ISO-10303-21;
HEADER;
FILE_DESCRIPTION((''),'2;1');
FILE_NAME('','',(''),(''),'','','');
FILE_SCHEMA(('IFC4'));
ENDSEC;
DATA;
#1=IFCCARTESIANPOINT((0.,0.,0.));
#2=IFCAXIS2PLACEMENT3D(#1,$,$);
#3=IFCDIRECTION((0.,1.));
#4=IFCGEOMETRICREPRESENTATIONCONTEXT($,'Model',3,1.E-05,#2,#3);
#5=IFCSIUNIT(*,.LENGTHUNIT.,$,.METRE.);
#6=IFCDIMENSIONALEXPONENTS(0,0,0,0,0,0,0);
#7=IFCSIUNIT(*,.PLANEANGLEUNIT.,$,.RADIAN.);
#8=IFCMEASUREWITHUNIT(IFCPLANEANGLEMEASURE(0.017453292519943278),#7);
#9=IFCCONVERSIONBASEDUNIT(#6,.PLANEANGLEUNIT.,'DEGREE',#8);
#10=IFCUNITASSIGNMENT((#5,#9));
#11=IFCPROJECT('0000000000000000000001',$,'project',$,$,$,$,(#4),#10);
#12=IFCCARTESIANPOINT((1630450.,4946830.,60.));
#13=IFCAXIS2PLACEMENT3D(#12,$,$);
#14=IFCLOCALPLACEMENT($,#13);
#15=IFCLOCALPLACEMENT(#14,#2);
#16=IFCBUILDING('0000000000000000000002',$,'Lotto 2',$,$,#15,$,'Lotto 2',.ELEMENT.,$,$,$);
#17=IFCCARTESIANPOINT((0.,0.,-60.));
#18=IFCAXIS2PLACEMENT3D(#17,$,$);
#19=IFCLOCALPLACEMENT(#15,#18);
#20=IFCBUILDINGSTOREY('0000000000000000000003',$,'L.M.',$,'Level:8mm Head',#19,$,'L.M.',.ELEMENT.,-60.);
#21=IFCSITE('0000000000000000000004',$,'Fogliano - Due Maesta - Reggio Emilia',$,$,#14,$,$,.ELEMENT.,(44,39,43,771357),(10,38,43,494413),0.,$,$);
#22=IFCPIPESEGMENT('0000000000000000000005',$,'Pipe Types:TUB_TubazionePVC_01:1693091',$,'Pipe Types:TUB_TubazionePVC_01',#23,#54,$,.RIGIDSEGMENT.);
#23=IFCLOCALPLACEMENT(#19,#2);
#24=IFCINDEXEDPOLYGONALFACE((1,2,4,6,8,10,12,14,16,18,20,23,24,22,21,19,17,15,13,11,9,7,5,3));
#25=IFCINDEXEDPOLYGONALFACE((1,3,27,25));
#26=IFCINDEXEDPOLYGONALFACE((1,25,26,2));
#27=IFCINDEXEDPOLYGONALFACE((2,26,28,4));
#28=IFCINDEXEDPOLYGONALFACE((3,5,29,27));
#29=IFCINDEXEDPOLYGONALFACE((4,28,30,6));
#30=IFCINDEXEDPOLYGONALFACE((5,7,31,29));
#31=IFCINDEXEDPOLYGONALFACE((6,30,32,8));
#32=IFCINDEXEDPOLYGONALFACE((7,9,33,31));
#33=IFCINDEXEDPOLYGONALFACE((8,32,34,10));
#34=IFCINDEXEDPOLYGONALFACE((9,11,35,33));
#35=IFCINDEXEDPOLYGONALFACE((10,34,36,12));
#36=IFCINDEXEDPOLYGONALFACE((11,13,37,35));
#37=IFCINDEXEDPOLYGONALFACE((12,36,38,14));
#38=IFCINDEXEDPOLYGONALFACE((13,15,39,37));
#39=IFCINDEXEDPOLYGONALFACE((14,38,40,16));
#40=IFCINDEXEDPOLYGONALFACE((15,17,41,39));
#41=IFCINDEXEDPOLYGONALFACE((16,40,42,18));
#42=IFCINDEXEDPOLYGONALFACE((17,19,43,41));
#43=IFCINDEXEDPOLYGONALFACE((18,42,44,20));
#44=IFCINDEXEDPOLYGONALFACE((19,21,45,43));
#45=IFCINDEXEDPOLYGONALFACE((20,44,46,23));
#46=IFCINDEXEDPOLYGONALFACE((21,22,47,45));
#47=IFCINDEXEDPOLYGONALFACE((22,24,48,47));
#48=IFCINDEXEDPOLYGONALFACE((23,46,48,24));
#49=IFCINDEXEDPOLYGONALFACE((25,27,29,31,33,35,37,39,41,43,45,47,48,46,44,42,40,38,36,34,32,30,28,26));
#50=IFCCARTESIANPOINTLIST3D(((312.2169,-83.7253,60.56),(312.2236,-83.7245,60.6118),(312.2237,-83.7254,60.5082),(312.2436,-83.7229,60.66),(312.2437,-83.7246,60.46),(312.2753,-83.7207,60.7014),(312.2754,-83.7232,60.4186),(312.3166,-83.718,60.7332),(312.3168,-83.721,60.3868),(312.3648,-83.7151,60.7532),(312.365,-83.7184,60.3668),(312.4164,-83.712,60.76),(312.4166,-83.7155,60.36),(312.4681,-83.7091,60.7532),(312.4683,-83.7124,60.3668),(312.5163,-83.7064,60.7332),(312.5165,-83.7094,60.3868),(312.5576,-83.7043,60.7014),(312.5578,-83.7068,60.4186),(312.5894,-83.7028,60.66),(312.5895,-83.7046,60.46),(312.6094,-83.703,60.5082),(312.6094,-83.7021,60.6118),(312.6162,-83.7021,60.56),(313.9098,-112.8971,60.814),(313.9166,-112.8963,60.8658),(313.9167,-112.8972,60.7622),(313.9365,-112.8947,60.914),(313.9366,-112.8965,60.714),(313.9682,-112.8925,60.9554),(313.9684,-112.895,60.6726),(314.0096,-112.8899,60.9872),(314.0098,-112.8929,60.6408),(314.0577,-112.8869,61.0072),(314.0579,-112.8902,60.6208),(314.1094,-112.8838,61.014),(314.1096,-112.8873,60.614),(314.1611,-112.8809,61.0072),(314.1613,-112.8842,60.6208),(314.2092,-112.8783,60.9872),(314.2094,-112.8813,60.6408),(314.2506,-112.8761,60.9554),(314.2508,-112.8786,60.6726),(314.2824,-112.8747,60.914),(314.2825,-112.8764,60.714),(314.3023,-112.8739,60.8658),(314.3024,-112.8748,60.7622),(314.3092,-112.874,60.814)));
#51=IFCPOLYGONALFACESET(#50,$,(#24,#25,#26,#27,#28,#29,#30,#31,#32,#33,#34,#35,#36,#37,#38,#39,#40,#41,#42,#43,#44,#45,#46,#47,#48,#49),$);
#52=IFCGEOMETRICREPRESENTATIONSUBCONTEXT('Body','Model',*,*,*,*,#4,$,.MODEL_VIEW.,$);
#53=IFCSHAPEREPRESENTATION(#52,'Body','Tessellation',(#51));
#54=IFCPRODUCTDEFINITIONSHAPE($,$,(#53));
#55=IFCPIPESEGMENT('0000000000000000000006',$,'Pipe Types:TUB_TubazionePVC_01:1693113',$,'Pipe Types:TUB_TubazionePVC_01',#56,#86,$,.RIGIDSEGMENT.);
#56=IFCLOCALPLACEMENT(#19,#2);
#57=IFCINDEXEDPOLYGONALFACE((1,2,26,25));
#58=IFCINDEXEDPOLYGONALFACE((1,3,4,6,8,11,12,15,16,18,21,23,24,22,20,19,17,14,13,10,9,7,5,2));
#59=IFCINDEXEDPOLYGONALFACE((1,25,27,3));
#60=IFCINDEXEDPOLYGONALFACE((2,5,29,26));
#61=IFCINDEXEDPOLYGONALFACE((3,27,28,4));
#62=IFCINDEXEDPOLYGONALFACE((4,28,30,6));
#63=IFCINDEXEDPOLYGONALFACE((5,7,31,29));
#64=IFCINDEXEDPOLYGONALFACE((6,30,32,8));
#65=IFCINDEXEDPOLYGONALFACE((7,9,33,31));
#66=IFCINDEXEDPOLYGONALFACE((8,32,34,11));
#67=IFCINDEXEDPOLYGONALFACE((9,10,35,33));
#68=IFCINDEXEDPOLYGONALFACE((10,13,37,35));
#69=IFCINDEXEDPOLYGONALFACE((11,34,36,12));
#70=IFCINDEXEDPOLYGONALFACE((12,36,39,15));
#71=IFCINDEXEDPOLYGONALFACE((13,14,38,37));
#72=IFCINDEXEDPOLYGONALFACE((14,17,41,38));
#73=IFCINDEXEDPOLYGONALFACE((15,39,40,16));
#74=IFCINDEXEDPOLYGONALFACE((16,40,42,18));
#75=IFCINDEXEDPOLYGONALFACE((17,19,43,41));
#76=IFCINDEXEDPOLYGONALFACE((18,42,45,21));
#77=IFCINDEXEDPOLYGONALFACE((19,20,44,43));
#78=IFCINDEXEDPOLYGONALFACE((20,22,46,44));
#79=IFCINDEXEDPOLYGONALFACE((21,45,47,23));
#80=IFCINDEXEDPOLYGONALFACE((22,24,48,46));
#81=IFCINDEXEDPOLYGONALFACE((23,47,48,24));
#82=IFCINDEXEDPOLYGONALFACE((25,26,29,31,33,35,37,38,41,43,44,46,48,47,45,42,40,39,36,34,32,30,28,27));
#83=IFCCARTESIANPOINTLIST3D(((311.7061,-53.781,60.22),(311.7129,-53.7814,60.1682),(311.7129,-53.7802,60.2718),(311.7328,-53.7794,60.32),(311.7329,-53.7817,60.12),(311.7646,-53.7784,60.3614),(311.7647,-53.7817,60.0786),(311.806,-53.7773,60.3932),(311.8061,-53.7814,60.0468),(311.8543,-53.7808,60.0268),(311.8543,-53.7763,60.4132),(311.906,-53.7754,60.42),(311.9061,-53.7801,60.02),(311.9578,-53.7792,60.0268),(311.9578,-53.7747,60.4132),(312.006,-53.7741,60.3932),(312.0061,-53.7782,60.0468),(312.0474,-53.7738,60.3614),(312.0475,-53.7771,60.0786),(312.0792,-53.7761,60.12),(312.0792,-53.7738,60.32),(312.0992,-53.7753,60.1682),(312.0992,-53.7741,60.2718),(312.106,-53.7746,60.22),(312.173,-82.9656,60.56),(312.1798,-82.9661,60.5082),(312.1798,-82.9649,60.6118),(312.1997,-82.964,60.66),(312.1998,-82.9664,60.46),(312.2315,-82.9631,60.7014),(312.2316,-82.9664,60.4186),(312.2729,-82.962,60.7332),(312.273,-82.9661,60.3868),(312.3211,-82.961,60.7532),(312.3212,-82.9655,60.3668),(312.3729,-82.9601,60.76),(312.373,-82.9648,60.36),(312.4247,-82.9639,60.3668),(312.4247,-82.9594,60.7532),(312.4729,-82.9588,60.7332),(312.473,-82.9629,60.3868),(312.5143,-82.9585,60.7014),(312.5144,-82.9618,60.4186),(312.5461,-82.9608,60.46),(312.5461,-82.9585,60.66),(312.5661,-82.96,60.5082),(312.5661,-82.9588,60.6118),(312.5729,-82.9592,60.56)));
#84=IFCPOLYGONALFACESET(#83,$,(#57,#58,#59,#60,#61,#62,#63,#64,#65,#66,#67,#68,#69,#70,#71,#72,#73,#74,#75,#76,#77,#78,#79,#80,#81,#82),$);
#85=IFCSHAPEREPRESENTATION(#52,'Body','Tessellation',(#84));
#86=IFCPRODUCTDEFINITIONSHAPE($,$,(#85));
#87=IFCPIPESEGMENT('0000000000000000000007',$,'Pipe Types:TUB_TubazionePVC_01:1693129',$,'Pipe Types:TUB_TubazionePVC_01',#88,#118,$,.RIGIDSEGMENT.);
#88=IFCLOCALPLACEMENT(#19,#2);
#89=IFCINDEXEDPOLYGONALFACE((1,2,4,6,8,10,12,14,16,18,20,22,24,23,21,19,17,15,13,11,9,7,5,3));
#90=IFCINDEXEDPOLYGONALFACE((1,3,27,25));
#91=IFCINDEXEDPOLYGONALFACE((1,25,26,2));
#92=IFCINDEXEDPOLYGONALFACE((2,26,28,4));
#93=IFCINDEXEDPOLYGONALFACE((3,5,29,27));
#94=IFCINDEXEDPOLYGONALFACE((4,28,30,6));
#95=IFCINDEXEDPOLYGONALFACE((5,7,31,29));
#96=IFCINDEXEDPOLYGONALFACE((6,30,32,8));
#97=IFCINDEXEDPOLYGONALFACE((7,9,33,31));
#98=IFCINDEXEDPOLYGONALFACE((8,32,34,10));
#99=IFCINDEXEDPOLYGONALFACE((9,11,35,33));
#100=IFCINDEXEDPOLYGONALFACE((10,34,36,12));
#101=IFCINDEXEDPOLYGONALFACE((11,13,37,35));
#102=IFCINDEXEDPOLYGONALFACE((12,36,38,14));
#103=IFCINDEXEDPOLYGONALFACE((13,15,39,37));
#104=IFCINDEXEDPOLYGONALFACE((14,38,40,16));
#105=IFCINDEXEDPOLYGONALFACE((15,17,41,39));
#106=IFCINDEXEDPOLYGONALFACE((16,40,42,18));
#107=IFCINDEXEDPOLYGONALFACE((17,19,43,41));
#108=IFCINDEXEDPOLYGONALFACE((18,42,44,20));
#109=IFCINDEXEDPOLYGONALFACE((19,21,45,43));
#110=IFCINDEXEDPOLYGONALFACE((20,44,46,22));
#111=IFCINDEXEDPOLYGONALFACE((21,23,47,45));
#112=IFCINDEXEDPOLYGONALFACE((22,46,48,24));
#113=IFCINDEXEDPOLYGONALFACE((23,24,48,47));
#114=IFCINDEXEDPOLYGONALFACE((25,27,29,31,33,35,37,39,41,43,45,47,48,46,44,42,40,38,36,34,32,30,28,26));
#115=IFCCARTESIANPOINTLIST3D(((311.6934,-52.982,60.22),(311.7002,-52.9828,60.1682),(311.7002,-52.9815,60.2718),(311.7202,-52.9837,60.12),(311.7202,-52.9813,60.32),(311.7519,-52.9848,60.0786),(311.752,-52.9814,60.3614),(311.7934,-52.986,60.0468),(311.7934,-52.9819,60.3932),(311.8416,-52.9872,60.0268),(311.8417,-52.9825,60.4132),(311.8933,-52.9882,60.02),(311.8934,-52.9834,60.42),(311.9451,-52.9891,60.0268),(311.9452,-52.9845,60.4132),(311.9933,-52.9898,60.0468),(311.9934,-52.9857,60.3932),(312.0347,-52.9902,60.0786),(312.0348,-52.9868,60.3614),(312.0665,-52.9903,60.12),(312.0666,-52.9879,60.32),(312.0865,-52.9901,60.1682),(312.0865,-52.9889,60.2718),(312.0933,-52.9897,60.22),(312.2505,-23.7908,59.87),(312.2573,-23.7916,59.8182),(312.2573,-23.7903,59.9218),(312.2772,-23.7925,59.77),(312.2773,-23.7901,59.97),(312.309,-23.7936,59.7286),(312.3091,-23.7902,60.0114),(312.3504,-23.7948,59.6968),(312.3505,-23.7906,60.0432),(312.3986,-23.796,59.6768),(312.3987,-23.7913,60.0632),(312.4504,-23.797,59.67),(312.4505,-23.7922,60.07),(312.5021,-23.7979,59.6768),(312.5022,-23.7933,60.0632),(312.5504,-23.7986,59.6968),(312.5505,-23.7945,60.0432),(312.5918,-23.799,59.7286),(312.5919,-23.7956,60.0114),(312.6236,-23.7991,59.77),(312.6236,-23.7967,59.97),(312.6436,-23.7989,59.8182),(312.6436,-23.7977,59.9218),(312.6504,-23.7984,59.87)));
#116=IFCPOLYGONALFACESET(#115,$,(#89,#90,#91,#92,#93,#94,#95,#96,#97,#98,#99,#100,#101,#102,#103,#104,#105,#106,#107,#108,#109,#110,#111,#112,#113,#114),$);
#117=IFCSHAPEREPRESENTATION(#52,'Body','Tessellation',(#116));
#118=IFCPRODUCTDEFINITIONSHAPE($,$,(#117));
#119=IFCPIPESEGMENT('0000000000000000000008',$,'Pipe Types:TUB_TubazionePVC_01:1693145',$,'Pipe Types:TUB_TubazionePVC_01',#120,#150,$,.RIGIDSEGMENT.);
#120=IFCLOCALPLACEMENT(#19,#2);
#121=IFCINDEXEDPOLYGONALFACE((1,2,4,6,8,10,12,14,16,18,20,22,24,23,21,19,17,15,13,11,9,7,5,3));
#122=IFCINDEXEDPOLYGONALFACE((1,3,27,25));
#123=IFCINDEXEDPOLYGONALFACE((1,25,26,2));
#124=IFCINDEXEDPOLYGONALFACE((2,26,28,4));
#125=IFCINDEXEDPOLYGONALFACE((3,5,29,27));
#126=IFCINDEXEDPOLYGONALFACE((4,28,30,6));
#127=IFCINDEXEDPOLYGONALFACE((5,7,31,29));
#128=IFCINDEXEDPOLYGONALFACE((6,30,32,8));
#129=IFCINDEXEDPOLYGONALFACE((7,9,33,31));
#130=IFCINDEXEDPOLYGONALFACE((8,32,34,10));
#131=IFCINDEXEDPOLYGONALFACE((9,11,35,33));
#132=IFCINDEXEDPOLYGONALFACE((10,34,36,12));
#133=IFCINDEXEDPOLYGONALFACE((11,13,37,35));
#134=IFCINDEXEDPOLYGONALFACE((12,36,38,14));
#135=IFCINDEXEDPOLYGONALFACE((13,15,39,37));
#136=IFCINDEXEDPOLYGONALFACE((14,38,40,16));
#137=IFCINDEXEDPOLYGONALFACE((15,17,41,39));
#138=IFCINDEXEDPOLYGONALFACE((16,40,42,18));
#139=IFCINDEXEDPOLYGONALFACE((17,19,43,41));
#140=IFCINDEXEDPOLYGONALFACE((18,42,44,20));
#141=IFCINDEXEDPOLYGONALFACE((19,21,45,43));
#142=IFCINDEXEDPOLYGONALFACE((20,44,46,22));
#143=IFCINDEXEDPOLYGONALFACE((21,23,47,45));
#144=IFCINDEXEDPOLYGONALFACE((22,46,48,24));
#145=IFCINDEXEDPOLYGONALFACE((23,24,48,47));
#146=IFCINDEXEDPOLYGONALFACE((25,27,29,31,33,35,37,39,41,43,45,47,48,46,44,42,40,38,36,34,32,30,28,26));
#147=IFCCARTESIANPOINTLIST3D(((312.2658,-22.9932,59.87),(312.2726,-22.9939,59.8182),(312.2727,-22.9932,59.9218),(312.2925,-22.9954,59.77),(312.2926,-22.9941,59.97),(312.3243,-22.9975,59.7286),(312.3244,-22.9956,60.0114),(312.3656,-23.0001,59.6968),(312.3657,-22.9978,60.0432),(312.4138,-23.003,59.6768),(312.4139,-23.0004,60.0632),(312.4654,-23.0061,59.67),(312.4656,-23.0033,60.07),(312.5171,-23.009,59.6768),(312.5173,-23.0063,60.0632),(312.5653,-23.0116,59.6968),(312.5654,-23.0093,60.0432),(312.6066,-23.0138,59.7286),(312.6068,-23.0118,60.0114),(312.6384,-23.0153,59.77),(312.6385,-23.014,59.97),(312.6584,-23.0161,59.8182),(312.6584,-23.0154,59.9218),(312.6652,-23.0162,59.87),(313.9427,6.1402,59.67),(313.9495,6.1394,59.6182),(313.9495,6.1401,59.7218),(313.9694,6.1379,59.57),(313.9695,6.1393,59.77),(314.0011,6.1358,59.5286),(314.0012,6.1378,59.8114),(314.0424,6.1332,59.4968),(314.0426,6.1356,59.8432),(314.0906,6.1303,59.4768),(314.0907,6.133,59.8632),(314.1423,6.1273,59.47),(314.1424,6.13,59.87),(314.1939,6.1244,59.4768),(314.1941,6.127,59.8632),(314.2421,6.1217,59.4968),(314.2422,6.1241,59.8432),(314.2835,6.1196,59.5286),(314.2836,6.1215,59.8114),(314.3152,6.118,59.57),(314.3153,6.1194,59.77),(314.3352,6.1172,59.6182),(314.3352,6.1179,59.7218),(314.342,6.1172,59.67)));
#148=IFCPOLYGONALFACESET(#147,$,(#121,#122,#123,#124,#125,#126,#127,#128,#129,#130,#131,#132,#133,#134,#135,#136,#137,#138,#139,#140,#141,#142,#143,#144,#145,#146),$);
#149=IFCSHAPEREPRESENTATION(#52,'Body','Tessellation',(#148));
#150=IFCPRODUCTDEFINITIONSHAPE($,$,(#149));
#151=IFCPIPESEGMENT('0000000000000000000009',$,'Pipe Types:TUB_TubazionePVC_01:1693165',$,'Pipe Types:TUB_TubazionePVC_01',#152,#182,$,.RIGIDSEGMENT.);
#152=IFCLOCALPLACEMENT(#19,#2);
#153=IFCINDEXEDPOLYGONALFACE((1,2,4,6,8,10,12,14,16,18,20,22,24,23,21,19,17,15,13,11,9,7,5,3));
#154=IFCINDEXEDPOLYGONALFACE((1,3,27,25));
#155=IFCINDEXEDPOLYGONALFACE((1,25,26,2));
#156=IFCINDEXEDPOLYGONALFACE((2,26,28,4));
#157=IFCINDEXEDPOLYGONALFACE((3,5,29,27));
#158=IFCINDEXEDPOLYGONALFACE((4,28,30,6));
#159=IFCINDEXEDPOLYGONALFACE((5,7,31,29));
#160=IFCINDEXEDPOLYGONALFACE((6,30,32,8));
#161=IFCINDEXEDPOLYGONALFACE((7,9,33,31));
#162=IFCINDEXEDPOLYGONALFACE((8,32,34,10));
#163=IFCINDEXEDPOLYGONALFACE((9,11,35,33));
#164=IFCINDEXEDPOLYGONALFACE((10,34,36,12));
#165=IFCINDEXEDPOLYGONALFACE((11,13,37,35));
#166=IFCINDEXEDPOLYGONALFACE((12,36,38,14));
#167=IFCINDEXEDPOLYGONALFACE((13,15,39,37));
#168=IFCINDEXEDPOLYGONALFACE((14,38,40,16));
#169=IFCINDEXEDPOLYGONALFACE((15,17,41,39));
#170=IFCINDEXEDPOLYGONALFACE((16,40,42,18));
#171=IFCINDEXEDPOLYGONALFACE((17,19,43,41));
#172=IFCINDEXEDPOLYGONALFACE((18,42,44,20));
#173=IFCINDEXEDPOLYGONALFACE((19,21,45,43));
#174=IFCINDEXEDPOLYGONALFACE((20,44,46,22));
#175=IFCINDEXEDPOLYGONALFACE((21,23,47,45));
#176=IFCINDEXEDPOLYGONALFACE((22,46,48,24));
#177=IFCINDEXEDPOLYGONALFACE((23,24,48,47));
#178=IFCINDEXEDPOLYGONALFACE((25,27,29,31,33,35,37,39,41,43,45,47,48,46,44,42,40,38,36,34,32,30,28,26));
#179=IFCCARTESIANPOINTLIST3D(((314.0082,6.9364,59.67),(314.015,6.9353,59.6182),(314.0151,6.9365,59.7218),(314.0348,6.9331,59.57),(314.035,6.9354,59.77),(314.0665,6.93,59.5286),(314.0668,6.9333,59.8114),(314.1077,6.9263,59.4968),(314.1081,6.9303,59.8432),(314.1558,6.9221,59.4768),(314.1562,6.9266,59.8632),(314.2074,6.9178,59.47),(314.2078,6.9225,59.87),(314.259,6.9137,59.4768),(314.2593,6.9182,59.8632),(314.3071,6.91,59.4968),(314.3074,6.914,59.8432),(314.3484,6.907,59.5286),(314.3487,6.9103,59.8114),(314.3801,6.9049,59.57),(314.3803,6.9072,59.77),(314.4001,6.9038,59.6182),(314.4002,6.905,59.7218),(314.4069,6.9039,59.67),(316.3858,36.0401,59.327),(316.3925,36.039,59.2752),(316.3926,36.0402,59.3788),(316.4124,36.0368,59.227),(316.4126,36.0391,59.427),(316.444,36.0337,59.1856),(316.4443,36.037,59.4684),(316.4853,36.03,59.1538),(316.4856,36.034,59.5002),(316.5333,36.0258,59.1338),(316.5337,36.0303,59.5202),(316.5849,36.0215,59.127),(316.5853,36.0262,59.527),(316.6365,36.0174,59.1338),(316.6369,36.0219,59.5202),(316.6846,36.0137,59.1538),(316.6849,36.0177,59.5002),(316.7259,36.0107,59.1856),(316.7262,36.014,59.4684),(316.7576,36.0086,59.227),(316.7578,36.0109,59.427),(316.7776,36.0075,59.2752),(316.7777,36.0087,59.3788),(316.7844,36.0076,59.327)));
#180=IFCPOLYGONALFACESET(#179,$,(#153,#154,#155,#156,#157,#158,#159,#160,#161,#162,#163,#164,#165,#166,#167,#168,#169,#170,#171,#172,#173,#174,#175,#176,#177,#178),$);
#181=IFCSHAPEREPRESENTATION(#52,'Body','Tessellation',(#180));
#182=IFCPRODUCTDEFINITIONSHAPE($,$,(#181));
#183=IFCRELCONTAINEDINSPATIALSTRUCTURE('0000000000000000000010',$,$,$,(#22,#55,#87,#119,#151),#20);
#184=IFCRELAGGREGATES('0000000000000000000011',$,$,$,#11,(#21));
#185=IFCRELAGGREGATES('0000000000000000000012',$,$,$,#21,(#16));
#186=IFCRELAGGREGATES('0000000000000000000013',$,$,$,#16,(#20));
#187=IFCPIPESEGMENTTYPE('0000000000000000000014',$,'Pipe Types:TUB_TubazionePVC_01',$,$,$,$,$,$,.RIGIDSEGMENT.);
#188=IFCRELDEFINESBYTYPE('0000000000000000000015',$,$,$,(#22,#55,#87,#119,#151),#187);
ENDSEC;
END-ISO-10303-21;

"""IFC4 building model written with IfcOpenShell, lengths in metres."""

from ifc_helpers import new_model, entity, si_unit, converted_unit, direction, frame, origin, place, context, subcontext, project, spatial, arc, indexed_curve, outline, extrude, type_object, element, save


model = new_model("IFC4")

# Units and contexts
model_context = context("Model", 3, precision=1e-05, world=origin(), true_north=direction((0.0, 1.0)))
body_context = subcontext(model_context, "Body", "Model", "MODEL_VIEW")
ifc_project = project(units=[si_unit("LENGTHUNIT", "METRE"), converted_unit("PLANEANGLEUNIT", "DEGREE", entity("IfcPlaneAngleMeasure", 0.017453292519943278), si_unit("PLANEANGLEUNIT", "RADIAN"), dimensions=[0, 0, 0, 0, 0, 0, 0])], contexts=[model_context])

# Site, building, storey
site_placement = place(None, frame((1630450.0, 4946830.0, 60.0)))
site = spatial("IfcSite", under=ifc_project, at=site_placement, Name="Fogliano - Due Maesta - Reggio Emilia", CompositionType="ELEMENT", RefLatitude=(44, 39, 43, 771357), RefLongitude=(10, 38, 43, 494413), RefElevation=0.0)
building_placement = place(site_placement, origin())
building = spatial("IfcBuilding", under=site, at=building_placement, Name="Lotto 2", LongName="Lotto 2", CompositionType="ELEMENT")
storey_placement = place(building_placement, frame((0.0, 0.0, -60.0)))
storey = spatial("IfcBuildingStorey", under=building, at=storey_placement, Name="L.M.", ObjectType="Level:8mm Head", LongName="L.M.", CompositionType="ELEMENT", Elevation=-60.0)

# Pipe segments
pipe_segment_type = type_object("IfcPipeSegmentType", Name="Pipe Types:TUB_TubazionePVC_01", PredefinedType="RIGIDSEGMENT")
pipe_segment_1_placement = place(storey_placement, origin())
element("IfcPipeSegment", 1, at=pipe_segment_1_placement, inside=storey, type_object=pipe_segment_type, Name="Pipe Types:TUB_TubazionePVC_01:1693091", ObjectType="Pipe Types:TUB_TubazionePVC_01", PredefinedType="RIGIDSEGMENT", context=body_context, shape_type="SweptSolid", body=[
    extrude(outline(indexed_curve([(0.2, 0.0), (0.1414, 0.1414), (0.0, 0.2), (-0.1414, 0.1414), (-0.2, 0.0), (-0.1414, -0.1414), (0.0, -0.2), (0.1414, -0.1414)], segments=[arc(1, 2, 3), arc(3, 4, 5), arc(5, 6, 7), arc(7, 8, 1)], self_intersect=False)), frame((314.1095, -112.8856, 60.814), z_axis=(-0.057935, 0.998283, -0.008692), x_axis=(0.99832, 0.057937, 0.0)), (0.0, 0.0, 1.0), 29.222),
])
pipe_segment_2_placement = place(storey_placement, origin())
element("IfcPipeSegment", 2, at=pipe_segment_2_placement, inside=storey, type_object=pipe_segment_type, Name="Pipe Types:TUB_TubazionePVC_01:1693113", ObjectType="Pipe Types:TUB_TubazionePVC_01", PredefinedType="RIGIDSEGMENT", context=body_context, shape_type="SweptSolid", body=[
    extrude(outline(indexed_curve([(0.2, 0.0), (0.1414, 0.1414), (0.0, 0.2), (-0.1414, 0.1414), (-0.2, 0.0), (-0.1414, -0.1414), (0.0, -0.2), (0.1414, -0.1414)], segments=[arc(1, 2, 3), arc(3, 4, 5), arc(5, 6, 7), arc(7, 8, 1)], self_intersect=False)), frame((311.906, -53.7778, 60.22), z_axis=(0.015995, -0.999804, 0.011648), x_axis=(0.999872, 0.015996, 0.0)), (0.0, 0.0, 1.0), 29.1904),
])
pipe_segment_3_placement = place(storey_placement, origin())
element("IfcPipeSegment", 3, at=pipe_segment_3_placement, inside=storey, type_object=pipe_segment_type, Name="Pipe Types:TUB_TubazionePVC_01:1693129", ObjectType="Pipe Types:TUB_TubazionePVC_01", PredefinedType="RIGIDSEGMENT", context=body_context, shape_type="SweptSolid", body=[
    extrude(outline(indexed_curve([(0.2, 0.0), (0.1414, 0.1414), (0.0, 0.2), (-0.1414, 0.1414), (-0.2, 0.0), (-0.1414, -0.1414), (0.0, -0.2), (0.1414, -0.1414)], segments=[arc(1, 2, 3), arc(3, 4, 5), arc(5, 6, 7), arc(7, 8, 1)], self_intersect=False)), frame((312.4504, -23.7946, 59.87), z_axis=(-0.019078, -0.999746, 0.011987), x_axis=(0.999818, -0.01908, 0.0)), (0.0, 0.0, 1.0), 29.1986),
])
pipe_segment_4_placement = place(storey_placement, origin())
element("IfcPipeSegment", 4, at=pipe_segment_4_placement, inside=storey, type_object=pipe_segment_type, Name="Pipe Types:TUB_TubazionePVC_01:1693145", ObjectType="Pipe Types:TUB_TubazionePVC_01", PredefinedType="RIGIDSEGMENT", context=body_context, shape_type="SweptSolid", body=[
    extrude(outline(indexed_curve([(0.2, 0.0), (0.1414, 0.1414), (0.0, 0.2), (-0.1414, 0.1414), (-0.2, 0.0), (-0.1414, -0.1414), (0.0, -0.2), (0.1414, -0.1414)], segments=[arc(1, 2, 3), arc(3, 4, 5), arc(5, 6, 7), arc(7, 8, 1)], self_intersect=False)), frame((314.1423, 6.1287, 59.67), z_axis=(-0.057461, -0.998324, 0.006853), x_axis=(0.998348, -0.057462, 0.0)), (0.0, 0.0, 1.0), 29.1823),
])
pipe_segment_5_placement = place(storey_placement, origin())
element("IfcPipeSegment", 5, at=pipe_segment_5_placement, inside=storey, type_object=pipe_segment_type, Name="Pipe Types:TUB_TubazionePVC_01:1693165", ObjectType="Pipe Types:TUB_TubazionePVC_01", PredefinedType="RIGIDSEGMENT", context=body_context, shape_type="SweptSolid", body=[
    extrude(outline(indexed_curve([(0.2, 0.0), (0.1414, 0.1414), (0.0, 0.2), (-0.1414, 0.1414), (-0.2, 0.0), (-0.1414, -0.1414), (0.0, -0.2), (0.1414, -0.1414)], segments=[arc(1, 2, 3), arc(3, 4, 5), arc(5, 6, 7), arc(7, 8, 1)], self_intersect=False)), frame((314.2076, 6.9202, 59.67), z_axis=(0.081415, 0.996611, -0.011746), x_axis=(0.99668, -0.08142, 0.0)), (0.0, 0.0, 1.0), 29.2027),
])

save(model, "model.ifc")
